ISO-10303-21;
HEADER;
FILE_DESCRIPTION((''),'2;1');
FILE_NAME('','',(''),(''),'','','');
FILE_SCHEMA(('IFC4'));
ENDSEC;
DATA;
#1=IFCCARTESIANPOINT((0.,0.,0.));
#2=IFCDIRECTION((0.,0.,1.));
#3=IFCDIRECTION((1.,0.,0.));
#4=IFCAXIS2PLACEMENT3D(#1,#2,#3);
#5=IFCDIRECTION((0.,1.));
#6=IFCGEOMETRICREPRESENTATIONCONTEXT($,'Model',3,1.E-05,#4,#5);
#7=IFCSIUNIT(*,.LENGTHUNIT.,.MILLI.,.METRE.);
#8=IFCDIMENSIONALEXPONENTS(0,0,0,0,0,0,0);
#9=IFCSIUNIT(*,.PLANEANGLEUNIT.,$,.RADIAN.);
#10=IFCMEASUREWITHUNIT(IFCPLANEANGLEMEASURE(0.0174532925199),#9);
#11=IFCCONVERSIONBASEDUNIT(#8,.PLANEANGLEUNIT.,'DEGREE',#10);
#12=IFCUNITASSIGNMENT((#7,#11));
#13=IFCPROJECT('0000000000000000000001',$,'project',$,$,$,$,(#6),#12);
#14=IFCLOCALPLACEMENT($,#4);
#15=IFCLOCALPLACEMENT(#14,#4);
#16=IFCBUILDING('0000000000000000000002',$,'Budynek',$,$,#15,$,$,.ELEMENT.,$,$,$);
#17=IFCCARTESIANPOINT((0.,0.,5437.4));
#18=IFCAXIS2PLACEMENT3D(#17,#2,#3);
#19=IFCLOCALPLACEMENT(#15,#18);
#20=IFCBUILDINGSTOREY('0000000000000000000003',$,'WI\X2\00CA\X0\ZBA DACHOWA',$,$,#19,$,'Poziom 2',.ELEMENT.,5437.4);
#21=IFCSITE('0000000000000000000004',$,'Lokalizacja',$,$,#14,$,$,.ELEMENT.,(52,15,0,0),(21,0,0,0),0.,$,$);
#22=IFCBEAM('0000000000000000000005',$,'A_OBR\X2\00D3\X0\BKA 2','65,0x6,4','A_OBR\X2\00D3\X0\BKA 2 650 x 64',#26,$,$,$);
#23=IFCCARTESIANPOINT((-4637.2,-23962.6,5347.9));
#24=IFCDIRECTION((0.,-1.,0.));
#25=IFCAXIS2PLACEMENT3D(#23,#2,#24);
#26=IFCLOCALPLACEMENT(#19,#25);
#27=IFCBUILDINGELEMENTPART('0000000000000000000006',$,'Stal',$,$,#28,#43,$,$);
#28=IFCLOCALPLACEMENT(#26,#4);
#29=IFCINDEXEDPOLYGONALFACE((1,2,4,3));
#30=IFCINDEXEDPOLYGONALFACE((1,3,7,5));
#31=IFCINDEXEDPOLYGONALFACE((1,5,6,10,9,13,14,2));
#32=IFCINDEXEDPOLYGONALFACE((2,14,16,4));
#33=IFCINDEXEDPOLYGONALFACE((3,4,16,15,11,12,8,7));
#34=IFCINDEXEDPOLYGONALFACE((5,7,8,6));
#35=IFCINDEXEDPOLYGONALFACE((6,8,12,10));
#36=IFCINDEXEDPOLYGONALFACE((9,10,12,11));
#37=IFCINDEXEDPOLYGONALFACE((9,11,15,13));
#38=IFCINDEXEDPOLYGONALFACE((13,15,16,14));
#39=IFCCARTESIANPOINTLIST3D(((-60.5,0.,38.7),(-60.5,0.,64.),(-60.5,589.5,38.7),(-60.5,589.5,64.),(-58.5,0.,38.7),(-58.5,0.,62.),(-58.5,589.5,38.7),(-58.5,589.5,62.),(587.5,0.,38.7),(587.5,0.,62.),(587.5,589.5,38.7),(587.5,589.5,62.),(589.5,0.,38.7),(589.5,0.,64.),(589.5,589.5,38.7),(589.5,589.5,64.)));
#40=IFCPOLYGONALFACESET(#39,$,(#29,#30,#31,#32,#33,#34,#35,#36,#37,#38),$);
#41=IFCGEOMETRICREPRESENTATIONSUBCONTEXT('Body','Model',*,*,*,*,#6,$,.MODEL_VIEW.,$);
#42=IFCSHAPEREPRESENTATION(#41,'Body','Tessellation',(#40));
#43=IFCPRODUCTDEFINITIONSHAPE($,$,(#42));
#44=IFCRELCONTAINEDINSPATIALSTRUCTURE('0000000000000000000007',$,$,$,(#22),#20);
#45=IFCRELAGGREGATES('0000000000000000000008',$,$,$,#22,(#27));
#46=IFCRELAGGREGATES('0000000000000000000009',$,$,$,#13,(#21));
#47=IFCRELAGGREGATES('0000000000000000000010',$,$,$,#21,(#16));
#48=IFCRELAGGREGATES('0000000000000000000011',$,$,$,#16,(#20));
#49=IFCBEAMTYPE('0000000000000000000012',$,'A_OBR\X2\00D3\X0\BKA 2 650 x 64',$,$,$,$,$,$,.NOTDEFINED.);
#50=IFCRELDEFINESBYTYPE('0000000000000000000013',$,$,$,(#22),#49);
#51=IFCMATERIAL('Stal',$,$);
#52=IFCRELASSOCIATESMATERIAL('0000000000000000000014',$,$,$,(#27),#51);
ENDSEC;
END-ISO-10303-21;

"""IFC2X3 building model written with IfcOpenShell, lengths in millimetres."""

from ifc_helpers import new_model, entity, si_unit, converted_unit, direction, frame, origin_with_axes, place, context, subcontext, project, spatial, polyline, outline, extrude, material, type_object, element, aggregate, save


model = new_model("IFC2X3")

# Units and contexts
model_context = context("Model", 3, precision=1e-05, world=origin_with_axes(), true_north=direction((0.0, 1.0)))
body_context = subcontext(model_context, "Body", "Model", "MODEL_VIEW")
ifc_project = project(units=[si_unit("LENGTHUNIT", "METRE", prefix="MILLI"), converted_unit("PLANEANGLEUNIT", "DEGREE", entity("IfcPlaneAngleMeasure", 0.0174532925199), si_unit("PLANEANGLEUNIT", "RADIAN"), dimensions=[0, 0, 0, 0, 0, 0, 0])], contexts=[model_context])

# Site, building, storey
site_placement = place(None, origin_with_axes())
site = spatial("IfcSite", under=ifc_project, at=site_placement, Name="Lokalizacja", CompositionType="ELEMENT", RefLatitude=(52, 15, 0, 0), RefLongitude=(21, 0, 0, 0), RefElevation=0.0)
building_placement = place(site_placement, origin_with_axes())
building = spatial("IfcBuilding", under=site, at=building_placement, Name="Budynek", CompositionType="ELEMENT")
storey_placement = place(building_placement, frame((0.0, 0.0, 5437.4), z_axis=(0.0, 0.0, 1.0), x_axis=(1.0, 0.0, 0.0)))
storey = spatial("IfcBuildingStorey", under=building, at=storey_placement, Name="WIÊZBA DACHOWA", LongName="Poziom 2", CompositionType="ELEMENT", Elevation=5437.4)

# Beam, building element part
ifc_material_1 = material(Name="Stal")
beam_type_1 = type_object("IfcBeamType", Name="A_OBRÓBKA 2 650 x 64", PredefinedType="NOTDEFINED")
beam_1_placement = place(storey_placement, frame((-4637.2, -23962.6, 5347.9), z_axis=(0.0, 0.0, 1.0), x_axis=(0.0, -1.0, 0.0)))
beam_1 = element("IfcBeam", 1, at=beam_1_placement, inside=storey, type_object=beam_type_1, Name="A_OBRÓBKA 2", Description="65,0x6,4", ObjectType="A_OBRÓBKA 2 650 x 64")
building_element_part_1_placement = place(beam_1_placement, origin_with_axes())
building_element_part_1 = element("IfcBuildingElementPart", 2, at=building_element_part_1_placement, material=ifc_material_1, Name="Stal", context=body_context, shape_type="SweptSolid", body=[
    extrude(outline(polyline([(-60.5, 64.0), (-60.5, 38.7), (-58.5, 38.7), (-58.5, 62.0), (587.5, 62.0), (587.5, 38.7), (589.5, 38.7), (589.5, 64.0), (-60.5, 64.0)])), frame((0.0, 589.5, 0.0), z_axis=(0.0, -1.0, 0.0), x_axis=(1.0, 0.0, 0.0)), (0.0, 0.0, 1.0), 589.5),
])
aggregate(beam_1, [building_element_part_1])

save(model, "model.ifc")
